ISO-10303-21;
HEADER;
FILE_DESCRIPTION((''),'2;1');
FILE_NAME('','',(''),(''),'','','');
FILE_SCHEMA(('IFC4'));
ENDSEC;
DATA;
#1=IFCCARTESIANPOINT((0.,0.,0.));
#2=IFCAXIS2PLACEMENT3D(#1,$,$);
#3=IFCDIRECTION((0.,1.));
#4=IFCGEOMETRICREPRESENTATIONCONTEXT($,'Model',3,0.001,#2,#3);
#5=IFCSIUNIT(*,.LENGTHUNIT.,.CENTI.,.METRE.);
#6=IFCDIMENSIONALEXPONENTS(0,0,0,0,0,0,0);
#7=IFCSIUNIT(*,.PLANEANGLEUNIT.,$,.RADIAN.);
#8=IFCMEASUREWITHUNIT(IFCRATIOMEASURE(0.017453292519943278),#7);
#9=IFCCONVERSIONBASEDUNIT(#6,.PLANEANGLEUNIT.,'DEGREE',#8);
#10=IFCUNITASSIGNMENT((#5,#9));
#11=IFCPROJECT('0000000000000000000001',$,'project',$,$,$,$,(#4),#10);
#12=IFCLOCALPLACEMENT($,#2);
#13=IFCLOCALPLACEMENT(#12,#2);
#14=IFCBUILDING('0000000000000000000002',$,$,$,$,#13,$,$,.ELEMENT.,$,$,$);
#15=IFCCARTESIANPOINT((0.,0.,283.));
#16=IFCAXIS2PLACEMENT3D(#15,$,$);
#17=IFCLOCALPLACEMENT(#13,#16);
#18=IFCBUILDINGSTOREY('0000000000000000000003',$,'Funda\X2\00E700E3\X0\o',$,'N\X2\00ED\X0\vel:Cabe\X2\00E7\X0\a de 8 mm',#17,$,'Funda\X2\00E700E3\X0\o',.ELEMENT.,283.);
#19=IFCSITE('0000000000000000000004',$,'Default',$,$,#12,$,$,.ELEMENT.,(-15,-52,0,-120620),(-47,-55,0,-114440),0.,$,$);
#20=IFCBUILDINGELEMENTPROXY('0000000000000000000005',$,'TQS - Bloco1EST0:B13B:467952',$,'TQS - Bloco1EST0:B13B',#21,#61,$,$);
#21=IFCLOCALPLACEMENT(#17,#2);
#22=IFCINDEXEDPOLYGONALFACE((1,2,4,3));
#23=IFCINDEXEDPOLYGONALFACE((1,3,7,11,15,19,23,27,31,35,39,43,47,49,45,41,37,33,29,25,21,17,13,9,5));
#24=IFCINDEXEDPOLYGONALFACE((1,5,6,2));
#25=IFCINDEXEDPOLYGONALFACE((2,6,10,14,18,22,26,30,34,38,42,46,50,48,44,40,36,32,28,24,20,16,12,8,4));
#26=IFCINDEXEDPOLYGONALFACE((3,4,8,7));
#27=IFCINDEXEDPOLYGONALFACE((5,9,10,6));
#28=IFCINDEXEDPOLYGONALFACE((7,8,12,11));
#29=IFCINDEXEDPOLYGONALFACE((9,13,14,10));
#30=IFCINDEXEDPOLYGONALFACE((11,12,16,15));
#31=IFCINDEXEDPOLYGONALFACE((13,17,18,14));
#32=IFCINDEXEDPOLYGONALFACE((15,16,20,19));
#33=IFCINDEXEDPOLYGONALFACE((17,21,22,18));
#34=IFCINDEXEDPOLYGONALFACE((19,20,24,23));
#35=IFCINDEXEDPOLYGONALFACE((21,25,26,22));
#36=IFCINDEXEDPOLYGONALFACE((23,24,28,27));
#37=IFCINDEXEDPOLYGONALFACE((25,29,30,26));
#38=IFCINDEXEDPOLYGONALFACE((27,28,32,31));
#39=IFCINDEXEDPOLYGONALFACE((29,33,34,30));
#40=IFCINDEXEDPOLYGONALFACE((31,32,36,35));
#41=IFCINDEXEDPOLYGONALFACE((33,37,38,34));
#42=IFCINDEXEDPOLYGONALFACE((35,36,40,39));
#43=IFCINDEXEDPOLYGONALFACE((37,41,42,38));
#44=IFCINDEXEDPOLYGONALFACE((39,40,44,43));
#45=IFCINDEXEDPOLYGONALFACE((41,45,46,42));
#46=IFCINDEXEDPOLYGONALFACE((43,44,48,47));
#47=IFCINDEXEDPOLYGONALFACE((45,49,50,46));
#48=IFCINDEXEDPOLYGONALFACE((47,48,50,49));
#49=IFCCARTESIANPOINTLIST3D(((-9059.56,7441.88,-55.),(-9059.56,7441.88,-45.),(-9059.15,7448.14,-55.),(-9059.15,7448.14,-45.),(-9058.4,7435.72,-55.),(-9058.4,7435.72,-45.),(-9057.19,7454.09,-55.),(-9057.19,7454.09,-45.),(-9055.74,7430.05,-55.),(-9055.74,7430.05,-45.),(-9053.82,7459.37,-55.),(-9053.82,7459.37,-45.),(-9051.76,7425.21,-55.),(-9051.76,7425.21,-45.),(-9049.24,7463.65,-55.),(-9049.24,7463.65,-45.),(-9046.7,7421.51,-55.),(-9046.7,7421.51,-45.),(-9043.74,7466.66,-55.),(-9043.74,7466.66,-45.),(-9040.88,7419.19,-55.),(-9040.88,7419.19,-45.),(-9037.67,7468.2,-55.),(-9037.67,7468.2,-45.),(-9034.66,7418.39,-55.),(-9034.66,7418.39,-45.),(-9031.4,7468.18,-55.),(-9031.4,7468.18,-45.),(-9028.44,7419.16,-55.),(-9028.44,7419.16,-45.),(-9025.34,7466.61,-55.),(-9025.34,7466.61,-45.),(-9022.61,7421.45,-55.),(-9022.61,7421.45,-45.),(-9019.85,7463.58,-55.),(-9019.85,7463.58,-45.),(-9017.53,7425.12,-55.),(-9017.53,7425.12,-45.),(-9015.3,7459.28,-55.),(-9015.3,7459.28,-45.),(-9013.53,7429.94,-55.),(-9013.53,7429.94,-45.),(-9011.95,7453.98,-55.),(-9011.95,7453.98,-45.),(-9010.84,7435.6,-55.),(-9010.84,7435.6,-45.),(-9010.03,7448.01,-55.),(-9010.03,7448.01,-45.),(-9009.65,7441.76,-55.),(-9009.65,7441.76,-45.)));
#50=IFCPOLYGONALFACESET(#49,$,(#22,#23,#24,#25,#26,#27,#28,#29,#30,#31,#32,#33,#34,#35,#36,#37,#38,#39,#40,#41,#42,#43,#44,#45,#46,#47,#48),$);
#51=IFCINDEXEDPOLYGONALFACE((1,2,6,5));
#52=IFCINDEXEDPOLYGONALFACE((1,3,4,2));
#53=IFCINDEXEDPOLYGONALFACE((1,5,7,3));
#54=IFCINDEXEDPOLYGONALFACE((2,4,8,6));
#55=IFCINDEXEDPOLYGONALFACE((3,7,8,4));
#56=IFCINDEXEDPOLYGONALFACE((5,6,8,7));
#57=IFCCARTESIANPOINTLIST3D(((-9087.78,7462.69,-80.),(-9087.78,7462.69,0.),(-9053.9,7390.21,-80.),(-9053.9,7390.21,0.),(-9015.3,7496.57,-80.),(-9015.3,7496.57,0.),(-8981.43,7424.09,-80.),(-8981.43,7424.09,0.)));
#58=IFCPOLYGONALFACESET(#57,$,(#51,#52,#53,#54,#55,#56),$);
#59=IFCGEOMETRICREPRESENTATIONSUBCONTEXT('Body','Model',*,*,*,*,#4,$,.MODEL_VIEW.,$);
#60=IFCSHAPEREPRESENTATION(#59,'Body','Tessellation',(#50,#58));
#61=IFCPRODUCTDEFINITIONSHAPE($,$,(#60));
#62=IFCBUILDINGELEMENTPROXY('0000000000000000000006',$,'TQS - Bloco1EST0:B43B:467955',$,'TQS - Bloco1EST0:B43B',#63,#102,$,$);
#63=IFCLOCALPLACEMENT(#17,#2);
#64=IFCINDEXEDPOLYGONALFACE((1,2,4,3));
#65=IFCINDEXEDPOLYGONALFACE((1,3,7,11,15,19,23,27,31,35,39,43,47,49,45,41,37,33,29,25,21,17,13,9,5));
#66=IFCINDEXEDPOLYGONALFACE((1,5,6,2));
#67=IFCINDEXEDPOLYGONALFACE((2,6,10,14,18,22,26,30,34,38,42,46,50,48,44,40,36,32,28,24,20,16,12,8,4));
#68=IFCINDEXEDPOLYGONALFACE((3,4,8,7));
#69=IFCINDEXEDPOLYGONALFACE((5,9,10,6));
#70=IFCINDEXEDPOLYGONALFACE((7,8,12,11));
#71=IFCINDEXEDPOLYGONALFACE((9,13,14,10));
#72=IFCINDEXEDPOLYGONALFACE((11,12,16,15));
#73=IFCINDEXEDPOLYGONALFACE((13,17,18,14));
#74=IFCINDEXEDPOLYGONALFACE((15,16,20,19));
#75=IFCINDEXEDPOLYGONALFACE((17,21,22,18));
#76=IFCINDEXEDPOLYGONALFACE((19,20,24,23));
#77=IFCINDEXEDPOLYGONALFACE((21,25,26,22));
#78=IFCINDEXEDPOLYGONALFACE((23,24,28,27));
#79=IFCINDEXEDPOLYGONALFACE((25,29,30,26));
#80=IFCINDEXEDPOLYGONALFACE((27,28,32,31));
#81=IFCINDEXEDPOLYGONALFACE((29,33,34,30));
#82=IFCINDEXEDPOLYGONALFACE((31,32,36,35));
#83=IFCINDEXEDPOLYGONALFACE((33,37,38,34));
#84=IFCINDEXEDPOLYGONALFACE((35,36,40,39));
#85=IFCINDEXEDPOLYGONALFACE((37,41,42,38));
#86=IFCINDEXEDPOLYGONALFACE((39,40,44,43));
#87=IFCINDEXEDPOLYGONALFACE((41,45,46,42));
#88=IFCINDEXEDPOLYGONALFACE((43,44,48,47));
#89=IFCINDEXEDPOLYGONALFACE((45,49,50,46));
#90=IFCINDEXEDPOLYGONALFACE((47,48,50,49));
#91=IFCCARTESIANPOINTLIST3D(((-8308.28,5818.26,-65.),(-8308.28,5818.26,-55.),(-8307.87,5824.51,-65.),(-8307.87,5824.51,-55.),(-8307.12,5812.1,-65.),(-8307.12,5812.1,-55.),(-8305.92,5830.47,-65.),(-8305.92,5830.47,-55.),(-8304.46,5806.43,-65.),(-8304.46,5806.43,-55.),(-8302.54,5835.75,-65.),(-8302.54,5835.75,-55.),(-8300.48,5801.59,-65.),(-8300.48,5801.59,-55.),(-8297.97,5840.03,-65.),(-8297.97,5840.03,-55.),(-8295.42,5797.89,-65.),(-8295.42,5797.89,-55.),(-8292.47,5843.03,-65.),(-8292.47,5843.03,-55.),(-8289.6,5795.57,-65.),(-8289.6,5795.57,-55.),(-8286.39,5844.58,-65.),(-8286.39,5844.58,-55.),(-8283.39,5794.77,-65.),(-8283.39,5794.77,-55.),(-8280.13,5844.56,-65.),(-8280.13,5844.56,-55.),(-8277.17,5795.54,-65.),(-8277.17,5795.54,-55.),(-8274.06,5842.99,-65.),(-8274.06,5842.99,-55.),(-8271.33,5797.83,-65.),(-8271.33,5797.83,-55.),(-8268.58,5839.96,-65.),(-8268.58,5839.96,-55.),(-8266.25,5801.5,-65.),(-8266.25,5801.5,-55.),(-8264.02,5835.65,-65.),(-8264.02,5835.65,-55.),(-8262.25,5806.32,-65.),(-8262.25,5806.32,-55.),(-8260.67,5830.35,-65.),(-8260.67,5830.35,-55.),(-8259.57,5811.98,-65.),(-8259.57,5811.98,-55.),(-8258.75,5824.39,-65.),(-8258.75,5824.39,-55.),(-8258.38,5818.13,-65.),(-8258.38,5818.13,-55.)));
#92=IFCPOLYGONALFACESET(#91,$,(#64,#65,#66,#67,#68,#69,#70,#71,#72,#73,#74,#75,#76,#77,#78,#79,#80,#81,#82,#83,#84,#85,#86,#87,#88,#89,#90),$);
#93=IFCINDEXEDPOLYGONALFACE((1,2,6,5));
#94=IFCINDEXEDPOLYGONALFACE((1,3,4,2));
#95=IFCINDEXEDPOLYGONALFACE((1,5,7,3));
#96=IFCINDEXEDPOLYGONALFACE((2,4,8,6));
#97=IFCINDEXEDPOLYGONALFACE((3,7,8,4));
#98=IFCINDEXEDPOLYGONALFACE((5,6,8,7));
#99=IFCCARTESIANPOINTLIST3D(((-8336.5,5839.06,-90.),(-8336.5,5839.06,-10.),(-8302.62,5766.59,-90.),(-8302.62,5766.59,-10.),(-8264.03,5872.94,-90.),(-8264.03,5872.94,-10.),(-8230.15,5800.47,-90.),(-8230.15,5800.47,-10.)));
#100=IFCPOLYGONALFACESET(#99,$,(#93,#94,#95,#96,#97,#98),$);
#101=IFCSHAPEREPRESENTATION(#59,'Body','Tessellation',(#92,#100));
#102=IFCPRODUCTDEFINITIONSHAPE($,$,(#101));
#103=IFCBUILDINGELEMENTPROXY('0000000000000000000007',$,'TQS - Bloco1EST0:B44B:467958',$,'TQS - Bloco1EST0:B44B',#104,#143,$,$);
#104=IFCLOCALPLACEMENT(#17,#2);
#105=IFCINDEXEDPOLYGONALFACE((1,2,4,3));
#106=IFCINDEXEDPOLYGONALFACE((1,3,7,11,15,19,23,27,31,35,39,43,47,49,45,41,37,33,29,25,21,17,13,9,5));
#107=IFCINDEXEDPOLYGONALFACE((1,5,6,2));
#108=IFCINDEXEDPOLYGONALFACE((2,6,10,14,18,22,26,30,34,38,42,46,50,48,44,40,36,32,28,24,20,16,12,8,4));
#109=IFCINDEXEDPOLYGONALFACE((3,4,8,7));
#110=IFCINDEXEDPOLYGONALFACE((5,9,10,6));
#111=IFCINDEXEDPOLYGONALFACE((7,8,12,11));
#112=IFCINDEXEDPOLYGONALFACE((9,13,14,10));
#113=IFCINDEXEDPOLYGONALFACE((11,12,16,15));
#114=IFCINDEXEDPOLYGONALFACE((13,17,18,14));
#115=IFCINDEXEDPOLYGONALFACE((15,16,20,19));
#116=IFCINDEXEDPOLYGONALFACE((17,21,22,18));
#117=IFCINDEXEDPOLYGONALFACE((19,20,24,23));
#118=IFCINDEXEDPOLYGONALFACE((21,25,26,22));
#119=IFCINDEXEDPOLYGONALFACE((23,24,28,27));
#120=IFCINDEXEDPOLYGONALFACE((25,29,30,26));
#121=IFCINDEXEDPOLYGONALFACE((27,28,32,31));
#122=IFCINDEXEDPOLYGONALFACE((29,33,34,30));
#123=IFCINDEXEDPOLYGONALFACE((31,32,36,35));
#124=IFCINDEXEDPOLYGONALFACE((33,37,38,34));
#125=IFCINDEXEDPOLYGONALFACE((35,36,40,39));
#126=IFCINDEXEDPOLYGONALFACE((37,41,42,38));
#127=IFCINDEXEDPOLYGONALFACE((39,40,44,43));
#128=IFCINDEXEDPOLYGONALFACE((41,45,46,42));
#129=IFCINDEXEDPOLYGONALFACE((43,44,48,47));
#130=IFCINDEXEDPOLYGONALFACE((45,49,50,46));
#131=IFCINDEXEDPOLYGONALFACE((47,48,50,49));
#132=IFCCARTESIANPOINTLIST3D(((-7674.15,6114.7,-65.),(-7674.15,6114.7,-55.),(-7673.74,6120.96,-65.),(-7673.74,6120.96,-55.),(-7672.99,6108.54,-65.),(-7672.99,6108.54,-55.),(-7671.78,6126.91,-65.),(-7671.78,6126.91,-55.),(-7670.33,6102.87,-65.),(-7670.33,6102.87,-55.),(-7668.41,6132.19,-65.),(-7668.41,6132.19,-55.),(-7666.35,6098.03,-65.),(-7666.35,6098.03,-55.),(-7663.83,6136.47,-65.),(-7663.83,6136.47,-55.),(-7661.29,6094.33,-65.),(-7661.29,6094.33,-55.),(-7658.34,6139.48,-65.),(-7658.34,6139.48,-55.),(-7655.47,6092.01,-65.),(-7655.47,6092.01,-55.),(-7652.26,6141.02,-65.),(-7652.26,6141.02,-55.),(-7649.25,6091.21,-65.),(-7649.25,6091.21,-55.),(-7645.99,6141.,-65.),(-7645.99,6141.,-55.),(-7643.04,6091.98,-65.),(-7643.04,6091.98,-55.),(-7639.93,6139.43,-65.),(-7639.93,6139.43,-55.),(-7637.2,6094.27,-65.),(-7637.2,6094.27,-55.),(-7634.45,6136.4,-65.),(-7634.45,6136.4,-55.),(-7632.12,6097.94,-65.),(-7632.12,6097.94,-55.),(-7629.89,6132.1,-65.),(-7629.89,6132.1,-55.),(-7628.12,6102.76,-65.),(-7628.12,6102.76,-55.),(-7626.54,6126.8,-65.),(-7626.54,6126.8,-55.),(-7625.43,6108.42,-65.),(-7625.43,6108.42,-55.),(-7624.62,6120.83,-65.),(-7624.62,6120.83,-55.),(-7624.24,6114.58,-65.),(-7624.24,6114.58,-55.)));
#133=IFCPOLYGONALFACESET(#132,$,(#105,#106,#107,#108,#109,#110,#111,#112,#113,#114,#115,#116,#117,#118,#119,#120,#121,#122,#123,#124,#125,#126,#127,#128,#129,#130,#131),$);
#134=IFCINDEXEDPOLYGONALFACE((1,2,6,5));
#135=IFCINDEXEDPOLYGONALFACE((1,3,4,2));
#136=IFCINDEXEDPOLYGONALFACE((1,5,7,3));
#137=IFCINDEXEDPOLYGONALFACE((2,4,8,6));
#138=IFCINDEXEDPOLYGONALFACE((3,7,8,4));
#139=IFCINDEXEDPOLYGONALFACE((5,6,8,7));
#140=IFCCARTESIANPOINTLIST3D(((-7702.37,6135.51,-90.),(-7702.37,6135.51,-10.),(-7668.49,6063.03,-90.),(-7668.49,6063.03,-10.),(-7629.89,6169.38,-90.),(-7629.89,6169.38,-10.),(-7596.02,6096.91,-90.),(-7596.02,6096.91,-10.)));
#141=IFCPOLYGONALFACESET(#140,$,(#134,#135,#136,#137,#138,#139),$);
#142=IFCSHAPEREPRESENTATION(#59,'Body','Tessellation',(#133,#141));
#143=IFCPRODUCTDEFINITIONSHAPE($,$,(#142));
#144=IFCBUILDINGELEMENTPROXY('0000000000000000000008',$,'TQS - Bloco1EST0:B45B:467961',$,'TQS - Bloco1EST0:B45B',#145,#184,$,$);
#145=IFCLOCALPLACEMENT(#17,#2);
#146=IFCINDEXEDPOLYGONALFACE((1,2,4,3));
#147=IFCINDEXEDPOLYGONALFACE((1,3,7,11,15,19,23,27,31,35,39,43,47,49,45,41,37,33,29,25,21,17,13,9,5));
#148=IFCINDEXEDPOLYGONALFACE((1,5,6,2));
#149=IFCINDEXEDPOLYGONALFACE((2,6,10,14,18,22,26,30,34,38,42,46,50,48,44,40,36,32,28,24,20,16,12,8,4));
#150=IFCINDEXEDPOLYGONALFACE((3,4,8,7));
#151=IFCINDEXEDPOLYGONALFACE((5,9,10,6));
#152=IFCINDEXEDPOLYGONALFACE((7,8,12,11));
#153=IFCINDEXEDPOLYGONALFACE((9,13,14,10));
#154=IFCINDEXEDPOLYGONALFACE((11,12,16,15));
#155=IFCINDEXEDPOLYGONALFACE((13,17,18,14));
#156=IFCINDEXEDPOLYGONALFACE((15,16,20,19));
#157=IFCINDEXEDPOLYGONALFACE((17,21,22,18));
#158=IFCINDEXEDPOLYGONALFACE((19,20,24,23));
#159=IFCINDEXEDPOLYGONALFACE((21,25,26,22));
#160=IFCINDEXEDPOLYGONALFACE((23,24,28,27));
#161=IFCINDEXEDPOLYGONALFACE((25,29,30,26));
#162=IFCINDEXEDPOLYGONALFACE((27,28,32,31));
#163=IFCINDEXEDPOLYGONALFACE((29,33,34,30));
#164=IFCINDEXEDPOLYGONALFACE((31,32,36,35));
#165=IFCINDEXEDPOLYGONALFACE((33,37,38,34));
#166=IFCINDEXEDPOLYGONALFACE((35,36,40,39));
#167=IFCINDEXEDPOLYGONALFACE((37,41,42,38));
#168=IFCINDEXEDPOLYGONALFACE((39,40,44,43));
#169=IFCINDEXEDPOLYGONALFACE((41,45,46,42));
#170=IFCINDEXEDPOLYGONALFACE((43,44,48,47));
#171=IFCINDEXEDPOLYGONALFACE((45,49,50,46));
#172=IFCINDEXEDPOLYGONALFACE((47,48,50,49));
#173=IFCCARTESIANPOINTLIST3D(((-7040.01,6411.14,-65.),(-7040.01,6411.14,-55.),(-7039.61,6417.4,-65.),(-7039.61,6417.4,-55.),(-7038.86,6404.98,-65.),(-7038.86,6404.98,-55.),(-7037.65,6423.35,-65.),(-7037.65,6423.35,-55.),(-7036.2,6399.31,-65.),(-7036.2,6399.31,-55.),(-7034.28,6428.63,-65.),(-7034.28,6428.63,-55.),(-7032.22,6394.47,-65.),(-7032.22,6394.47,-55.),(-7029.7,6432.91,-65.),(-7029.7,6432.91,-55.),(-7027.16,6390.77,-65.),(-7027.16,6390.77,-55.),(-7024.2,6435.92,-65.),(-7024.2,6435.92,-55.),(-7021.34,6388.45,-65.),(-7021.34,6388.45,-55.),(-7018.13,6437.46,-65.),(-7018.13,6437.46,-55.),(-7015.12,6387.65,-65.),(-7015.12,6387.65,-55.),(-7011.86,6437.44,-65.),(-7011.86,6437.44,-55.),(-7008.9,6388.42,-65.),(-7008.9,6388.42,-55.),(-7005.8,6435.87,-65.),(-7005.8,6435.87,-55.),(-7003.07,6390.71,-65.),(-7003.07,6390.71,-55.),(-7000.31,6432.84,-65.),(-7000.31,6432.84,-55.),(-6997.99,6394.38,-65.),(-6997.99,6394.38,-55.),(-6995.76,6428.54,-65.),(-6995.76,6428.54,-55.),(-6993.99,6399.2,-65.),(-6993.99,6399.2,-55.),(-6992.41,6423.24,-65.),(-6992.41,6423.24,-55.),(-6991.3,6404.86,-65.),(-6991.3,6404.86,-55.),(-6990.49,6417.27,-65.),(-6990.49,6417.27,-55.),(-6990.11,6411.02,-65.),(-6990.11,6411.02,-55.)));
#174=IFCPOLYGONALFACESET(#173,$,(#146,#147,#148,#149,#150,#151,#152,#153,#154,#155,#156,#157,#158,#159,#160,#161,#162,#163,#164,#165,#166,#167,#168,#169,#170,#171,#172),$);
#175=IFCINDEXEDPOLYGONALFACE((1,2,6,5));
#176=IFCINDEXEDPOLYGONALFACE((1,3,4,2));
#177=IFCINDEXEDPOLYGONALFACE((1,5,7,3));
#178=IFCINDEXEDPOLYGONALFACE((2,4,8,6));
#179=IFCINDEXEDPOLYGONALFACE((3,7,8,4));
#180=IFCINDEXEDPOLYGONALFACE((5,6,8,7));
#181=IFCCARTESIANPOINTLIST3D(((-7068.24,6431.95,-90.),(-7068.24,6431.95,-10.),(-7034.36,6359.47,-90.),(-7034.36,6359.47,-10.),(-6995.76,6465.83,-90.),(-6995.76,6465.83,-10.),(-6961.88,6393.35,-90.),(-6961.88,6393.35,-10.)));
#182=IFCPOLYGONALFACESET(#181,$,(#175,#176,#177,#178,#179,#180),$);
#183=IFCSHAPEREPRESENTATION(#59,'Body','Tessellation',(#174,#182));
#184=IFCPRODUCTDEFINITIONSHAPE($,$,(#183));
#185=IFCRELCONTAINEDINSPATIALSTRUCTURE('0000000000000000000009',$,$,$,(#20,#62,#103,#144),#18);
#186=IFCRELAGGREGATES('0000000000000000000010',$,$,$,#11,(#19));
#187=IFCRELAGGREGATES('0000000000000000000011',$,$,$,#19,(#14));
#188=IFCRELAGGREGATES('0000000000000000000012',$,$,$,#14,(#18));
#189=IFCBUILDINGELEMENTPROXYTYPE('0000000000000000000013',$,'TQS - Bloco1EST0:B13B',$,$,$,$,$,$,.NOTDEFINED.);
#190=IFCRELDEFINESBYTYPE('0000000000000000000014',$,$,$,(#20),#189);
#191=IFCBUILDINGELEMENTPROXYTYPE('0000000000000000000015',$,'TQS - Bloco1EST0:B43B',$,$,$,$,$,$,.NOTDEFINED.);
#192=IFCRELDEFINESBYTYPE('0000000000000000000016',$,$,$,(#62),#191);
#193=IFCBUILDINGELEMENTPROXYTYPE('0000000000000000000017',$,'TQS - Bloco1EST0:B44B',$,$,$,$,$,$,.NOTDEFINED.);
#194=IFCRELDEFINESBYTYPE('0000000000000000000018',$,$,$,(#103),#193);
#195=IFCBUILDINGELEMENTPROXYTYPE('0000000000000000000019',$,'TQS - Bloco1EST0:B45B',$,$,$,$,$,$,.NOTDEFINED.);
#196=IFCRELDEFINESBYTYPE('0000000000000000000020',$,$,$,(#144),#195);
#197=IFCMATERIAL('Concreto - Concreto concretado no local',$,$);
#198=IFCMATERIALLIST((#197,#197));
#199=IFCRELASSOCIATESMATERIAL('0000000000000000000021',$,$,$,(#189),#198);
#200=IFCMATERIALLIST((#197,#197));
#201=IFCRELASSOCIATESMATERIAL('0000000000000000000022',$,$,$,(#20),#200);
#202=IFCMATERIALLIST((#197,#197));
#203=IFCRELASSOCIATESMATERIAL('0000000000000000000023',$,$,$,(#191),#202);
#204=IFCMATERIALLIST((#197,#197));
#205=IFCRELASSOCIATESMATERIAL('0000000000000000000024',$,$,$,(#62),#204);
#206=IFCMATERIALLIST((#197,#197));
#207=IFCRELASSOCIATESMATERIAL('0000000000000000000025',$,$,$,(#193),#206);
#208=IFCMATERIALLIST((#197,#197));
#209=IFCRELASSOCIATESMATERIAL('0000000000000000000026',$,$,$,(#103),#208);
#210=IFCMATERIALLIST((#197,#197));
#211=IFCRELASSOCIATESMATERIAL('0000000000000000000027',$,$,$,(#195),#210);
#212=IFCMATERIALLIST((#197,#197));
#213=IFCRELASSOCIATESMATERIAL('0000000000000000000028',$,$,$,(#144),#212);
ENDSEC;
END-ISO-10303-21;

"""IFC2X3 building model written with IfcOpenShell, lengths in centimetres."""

from ifc_helpers import new_model, entity, si_unit, converted_unit, direction, frame, frame_2d, origin, origin_2d_with_axis, place, context, subcontext, project, spatial, rectangle, circle, extrude, source, transform, mapped, material, material_list, type_object, type_shapes, element, save


model = new_model("IFC2X3")

# Units and contexts
model_context = context("Model", 3, precision=0.001, world=origin(), true_north=direction((0.0, 1.0)))
body_context = subcontext(model_context, "Body", "Model", "MODEL_VIEW")
ifc_project = project(units=[si_unit("LENGTHUNIT", "METRE", prefix="CENTI"), converted_unit("PLANEANGLEUNIT", "DEGREE", entity("IfcRatioMeasure", 0.017453292519943278), si_unit("PLANEANGLEUNIT", "RADIAN"), dimensions=[0, 0, 0, 0, 0, 0, 0])], contexts=[model_context])

# Site, building, storey
site_placement = place(None, origin())
site = spatial("IfcSite", under=ifc_project, at=site_placement, Name="Default", CompositionType="ELEMENT", RefLatitude=(-15, -52, 0, -120620), RefLongitude=(-47, -55, 0, -114440), RefElevation=0.0)
building_placement = place(site_placement, origin())
building = spatial("IfcBuilding", under=site, at=building_placement, CompositionType="ELEMENT")
storey_placement = place(building_placement, frame((0.0, 0.0, 283.0)))
storey = spatial("IfcBuildingStorey", under=building, at=storey_placement, Name="Fundação", ObjectType="Nível:Cabeça de 8 mm", LongName="Fundação", CompositionType="ELEMENT", Elevation=283.0)

# Building element proxies
ifc_material_1 = material(Name="Concreto - Concreto concretado no local")
ifc_material_list_1 = material_list([ifc_material_1, ifc_material_1])
ifc_material_list_2 = material_list([ifc_material_1, ifc_material_1])
building_element_proxy_type_1 = type_object("IfcBuildingElementProxyType", Name="TQS - Bloco1EST0:B13B", PredefinedType="NOTDEFINED", material=ifc_material_list_2)
shared_shape_1 = source(origin(), body_context, "Body", "SweptSolid", [
    extrude(circle(Radius=25.0, at=frame_2d((0.0, 0.0), x_axis=(1.0, 0.0))), frame((0.0, 0.0, -55.0)), (0.0, 0.0, 1.0), 10.0),
    extrude(rectangle(XDim=80.0, YDim=80.0, at=origin_2d_with_axis()), frame((0.0, 0.0, -80.0), z_axis=(0.0, 0.0, 1.0), x_axis=(-1.0, 0.0, 0.0)), (0.0, 0.0, 1.0), 80.0),
])
type_shapes(building_element_proxy_type_1, [shared_shape_1])
proxy_1_placement = place(storey_placement, frame((-9034.6, 7443.39, 0.0), z_axis=(0.0, 0.0, 1.0), x_axis=(0.905902, 0.423488, 0.0)))
element("IfcBuildingElementProxy", 1, at=proxy_1_placement, inside=storey, type_object=building_element_proxy_type_1, material=ifc_material_list_1, Name="TQS - Bloco1EST0:B13B:467952", ObjectType="TQS - Bloco1EST0:B13B", context=body_context, shape_type="MappedRepresentation", body=[
    mapped(shared_shape_1, transform((0.0, 0.0, 0.0), scale=1.0)),
])
ifc_material_list_3 = material_list([ifc_material_1, ifc_material_1])
ifc_material_list_4 = material_list([ifc_material_1, ifc_material_1])
building_element_proxy_type_2 = type_object("IfcBuildingElementProxyType", Name="TQS - Bloco1EST0:B43B", PredefinedType="NOTDEFINED", material=ifc_material_list_4)
shared_shape_2 = source(origin(), body_context, "Body", "SweptSolid", [
    extrude(circle(Radius=25.0, at=frame_2d((0.0, 0.0), x_axis=(1.0, 0.0))), frame((0.0, 0.0, -55.0)), (0.0, 0.0, 1.0), 10.0),
    extrude(rectangle(XDim=80.0, YDim=80.0, at=origin_2d_with_axis()), frame((0.0, 0.0, -80.0), z_axis=(0.0, 0.0, 1.0), x_axis=(-1.0, 0.0, 0.0)), (0.0, 0.0, 1.0), 80.0),
])
type_shapes(building_element_proxy_type_2, [shared_shape_2])
proxy_2_placement = place(storey_placement, frame((-8283.32, 5819.77, -10.0), z_axis=(0.0, 0.0, 1.0), x_axis=(0.905902, 0.423488, 0.0)))
element("IfcBuildingElementProxy", 2, at=proxy_2_placement, inside=storey, type_object=building_element_proxy_type_2, material=ifc_material_list_3, Name="TQS - Bloco1EST0:B43B:467955", ObjectType="TQS - Bloco1EST0:B43B", context=body_context, shape_type="MappedRepresentation", body=[
    mapped(shared_shape_2, transform((0.0, 0.0, 0.0), scale=1.0)),
])
ifc_material_list_5 = material_list([ifc_material_1, ifc_material_1])
ifc_material_list_6 = material_list([ifc_material_1, ifc_material_1])
building_element_proxy_type_3 = type_object("IfcBuildingElementProxyType", Name="TQS - Bloco1EST0:B44B", PredefinedType="NOTDEFINED", material=ifc_material_list_6)
shared_shape_3 = source(origin(), body_context, "Body", "SweptSolid", [
    extrude(circle(Radius=25.0, at=frame_2d((0.0, 0.0), x_axis=(1.0, 0.0))), frame((0.0, 0.0, -55.0)), (0.0, 0.0, 1.0), 10.0),
    extrude(rectangle(XDim=80.0, YDim=80.0, at=origin_2d_with_axis()), frame((0.0, 0.0, -80.0), z_axis=(0.0, 0.0, 1.0), x_axis=(-1.0, 0.0, 0.0)), (0.0, 0.0, 1.0), 80.0),
])
type_shapes(building_element_proxy_type_3, [shared_shape_3])
proxy_3_placement = place(storey_placement, frame((-7649.19, 6116.21, -10.0), z_axis=(0.0, 0.0, 1.0), x_axis=(0.905902, 0.423488, 0.0)))
element("IfcBuildingElementProxy", 3, at=proxy_3_placement, inside=storey, type_object=building_element_proxy_type_3, material=ifc_material_list_5, Name="TQS - Bloco1EST0:B44B:467958", ObjectType="TQS - Bloco1EST0:B44B", context=body_context, shape_type="MappedRepresentation", body=[
    mapped(shared_shape_3, transform((0.0, 0.0, 0.0), scale=1.0)),
])
ifc_material_list_7 = material_list([ifc_material_1, ifc_material_1])
ifc_material_list_8 = material_list([ifc_material_1, ifc_material_1])
building_element_proxy_type_4 = type_object("IfcBuildingElementProxyType", Name="TQS - Bloco1EST0:B45B", PredefinedType="NOTDEFINED", material=ifc_material_list_8)
shared_shape_4 = source(origin(), body_context, "Body", "SweptSolid", [
    extrude(circle(Radius=25.0, at=frame_2d((0.0, 0.0), x_axis=(1.0, 0.0))), frame((0.0, 0.0, -55.0)), (0.0, 0.0, 1.0), 10.0),
    extrude(rectangle(XDim=80.0, YDim=80.0, at=origin_2d_with_axis()), frame((0.0, 0.0, -80.0), z_axis=(0.0, 0.0, 1.0), x_axis=(-1.0, 0.0, 0.0)), (0.0, 0.0, 1.0), 80.0),
])
type_shapes(building_element_proxy_type_4, [shared_shape_4])
proxy_4_placement = place(storey_placement, frame((-7015.06, 6412.65, -10.0), z_axis=(0.0, 0.0, 1.0), x_axis=(0.905902, 0.423488, 0.0)))
element("IfcBuildingElementProxy", 4, at=proxy_4_placement, inside=storey, type_object=building_element_proxy_type_4, material=ifc_material_list_7, Name="TQS - Bloco1EST0:B45B:467961", ObjectType="TQS - Bloco1EST0:B45B", context=body_context, shape_type="MappedRepresentation", body=[
    mapped(shared_shape_4, transform((0.0, 0.0, 0.0), scale=1.0)),
])

save(model, "model.ifc")
